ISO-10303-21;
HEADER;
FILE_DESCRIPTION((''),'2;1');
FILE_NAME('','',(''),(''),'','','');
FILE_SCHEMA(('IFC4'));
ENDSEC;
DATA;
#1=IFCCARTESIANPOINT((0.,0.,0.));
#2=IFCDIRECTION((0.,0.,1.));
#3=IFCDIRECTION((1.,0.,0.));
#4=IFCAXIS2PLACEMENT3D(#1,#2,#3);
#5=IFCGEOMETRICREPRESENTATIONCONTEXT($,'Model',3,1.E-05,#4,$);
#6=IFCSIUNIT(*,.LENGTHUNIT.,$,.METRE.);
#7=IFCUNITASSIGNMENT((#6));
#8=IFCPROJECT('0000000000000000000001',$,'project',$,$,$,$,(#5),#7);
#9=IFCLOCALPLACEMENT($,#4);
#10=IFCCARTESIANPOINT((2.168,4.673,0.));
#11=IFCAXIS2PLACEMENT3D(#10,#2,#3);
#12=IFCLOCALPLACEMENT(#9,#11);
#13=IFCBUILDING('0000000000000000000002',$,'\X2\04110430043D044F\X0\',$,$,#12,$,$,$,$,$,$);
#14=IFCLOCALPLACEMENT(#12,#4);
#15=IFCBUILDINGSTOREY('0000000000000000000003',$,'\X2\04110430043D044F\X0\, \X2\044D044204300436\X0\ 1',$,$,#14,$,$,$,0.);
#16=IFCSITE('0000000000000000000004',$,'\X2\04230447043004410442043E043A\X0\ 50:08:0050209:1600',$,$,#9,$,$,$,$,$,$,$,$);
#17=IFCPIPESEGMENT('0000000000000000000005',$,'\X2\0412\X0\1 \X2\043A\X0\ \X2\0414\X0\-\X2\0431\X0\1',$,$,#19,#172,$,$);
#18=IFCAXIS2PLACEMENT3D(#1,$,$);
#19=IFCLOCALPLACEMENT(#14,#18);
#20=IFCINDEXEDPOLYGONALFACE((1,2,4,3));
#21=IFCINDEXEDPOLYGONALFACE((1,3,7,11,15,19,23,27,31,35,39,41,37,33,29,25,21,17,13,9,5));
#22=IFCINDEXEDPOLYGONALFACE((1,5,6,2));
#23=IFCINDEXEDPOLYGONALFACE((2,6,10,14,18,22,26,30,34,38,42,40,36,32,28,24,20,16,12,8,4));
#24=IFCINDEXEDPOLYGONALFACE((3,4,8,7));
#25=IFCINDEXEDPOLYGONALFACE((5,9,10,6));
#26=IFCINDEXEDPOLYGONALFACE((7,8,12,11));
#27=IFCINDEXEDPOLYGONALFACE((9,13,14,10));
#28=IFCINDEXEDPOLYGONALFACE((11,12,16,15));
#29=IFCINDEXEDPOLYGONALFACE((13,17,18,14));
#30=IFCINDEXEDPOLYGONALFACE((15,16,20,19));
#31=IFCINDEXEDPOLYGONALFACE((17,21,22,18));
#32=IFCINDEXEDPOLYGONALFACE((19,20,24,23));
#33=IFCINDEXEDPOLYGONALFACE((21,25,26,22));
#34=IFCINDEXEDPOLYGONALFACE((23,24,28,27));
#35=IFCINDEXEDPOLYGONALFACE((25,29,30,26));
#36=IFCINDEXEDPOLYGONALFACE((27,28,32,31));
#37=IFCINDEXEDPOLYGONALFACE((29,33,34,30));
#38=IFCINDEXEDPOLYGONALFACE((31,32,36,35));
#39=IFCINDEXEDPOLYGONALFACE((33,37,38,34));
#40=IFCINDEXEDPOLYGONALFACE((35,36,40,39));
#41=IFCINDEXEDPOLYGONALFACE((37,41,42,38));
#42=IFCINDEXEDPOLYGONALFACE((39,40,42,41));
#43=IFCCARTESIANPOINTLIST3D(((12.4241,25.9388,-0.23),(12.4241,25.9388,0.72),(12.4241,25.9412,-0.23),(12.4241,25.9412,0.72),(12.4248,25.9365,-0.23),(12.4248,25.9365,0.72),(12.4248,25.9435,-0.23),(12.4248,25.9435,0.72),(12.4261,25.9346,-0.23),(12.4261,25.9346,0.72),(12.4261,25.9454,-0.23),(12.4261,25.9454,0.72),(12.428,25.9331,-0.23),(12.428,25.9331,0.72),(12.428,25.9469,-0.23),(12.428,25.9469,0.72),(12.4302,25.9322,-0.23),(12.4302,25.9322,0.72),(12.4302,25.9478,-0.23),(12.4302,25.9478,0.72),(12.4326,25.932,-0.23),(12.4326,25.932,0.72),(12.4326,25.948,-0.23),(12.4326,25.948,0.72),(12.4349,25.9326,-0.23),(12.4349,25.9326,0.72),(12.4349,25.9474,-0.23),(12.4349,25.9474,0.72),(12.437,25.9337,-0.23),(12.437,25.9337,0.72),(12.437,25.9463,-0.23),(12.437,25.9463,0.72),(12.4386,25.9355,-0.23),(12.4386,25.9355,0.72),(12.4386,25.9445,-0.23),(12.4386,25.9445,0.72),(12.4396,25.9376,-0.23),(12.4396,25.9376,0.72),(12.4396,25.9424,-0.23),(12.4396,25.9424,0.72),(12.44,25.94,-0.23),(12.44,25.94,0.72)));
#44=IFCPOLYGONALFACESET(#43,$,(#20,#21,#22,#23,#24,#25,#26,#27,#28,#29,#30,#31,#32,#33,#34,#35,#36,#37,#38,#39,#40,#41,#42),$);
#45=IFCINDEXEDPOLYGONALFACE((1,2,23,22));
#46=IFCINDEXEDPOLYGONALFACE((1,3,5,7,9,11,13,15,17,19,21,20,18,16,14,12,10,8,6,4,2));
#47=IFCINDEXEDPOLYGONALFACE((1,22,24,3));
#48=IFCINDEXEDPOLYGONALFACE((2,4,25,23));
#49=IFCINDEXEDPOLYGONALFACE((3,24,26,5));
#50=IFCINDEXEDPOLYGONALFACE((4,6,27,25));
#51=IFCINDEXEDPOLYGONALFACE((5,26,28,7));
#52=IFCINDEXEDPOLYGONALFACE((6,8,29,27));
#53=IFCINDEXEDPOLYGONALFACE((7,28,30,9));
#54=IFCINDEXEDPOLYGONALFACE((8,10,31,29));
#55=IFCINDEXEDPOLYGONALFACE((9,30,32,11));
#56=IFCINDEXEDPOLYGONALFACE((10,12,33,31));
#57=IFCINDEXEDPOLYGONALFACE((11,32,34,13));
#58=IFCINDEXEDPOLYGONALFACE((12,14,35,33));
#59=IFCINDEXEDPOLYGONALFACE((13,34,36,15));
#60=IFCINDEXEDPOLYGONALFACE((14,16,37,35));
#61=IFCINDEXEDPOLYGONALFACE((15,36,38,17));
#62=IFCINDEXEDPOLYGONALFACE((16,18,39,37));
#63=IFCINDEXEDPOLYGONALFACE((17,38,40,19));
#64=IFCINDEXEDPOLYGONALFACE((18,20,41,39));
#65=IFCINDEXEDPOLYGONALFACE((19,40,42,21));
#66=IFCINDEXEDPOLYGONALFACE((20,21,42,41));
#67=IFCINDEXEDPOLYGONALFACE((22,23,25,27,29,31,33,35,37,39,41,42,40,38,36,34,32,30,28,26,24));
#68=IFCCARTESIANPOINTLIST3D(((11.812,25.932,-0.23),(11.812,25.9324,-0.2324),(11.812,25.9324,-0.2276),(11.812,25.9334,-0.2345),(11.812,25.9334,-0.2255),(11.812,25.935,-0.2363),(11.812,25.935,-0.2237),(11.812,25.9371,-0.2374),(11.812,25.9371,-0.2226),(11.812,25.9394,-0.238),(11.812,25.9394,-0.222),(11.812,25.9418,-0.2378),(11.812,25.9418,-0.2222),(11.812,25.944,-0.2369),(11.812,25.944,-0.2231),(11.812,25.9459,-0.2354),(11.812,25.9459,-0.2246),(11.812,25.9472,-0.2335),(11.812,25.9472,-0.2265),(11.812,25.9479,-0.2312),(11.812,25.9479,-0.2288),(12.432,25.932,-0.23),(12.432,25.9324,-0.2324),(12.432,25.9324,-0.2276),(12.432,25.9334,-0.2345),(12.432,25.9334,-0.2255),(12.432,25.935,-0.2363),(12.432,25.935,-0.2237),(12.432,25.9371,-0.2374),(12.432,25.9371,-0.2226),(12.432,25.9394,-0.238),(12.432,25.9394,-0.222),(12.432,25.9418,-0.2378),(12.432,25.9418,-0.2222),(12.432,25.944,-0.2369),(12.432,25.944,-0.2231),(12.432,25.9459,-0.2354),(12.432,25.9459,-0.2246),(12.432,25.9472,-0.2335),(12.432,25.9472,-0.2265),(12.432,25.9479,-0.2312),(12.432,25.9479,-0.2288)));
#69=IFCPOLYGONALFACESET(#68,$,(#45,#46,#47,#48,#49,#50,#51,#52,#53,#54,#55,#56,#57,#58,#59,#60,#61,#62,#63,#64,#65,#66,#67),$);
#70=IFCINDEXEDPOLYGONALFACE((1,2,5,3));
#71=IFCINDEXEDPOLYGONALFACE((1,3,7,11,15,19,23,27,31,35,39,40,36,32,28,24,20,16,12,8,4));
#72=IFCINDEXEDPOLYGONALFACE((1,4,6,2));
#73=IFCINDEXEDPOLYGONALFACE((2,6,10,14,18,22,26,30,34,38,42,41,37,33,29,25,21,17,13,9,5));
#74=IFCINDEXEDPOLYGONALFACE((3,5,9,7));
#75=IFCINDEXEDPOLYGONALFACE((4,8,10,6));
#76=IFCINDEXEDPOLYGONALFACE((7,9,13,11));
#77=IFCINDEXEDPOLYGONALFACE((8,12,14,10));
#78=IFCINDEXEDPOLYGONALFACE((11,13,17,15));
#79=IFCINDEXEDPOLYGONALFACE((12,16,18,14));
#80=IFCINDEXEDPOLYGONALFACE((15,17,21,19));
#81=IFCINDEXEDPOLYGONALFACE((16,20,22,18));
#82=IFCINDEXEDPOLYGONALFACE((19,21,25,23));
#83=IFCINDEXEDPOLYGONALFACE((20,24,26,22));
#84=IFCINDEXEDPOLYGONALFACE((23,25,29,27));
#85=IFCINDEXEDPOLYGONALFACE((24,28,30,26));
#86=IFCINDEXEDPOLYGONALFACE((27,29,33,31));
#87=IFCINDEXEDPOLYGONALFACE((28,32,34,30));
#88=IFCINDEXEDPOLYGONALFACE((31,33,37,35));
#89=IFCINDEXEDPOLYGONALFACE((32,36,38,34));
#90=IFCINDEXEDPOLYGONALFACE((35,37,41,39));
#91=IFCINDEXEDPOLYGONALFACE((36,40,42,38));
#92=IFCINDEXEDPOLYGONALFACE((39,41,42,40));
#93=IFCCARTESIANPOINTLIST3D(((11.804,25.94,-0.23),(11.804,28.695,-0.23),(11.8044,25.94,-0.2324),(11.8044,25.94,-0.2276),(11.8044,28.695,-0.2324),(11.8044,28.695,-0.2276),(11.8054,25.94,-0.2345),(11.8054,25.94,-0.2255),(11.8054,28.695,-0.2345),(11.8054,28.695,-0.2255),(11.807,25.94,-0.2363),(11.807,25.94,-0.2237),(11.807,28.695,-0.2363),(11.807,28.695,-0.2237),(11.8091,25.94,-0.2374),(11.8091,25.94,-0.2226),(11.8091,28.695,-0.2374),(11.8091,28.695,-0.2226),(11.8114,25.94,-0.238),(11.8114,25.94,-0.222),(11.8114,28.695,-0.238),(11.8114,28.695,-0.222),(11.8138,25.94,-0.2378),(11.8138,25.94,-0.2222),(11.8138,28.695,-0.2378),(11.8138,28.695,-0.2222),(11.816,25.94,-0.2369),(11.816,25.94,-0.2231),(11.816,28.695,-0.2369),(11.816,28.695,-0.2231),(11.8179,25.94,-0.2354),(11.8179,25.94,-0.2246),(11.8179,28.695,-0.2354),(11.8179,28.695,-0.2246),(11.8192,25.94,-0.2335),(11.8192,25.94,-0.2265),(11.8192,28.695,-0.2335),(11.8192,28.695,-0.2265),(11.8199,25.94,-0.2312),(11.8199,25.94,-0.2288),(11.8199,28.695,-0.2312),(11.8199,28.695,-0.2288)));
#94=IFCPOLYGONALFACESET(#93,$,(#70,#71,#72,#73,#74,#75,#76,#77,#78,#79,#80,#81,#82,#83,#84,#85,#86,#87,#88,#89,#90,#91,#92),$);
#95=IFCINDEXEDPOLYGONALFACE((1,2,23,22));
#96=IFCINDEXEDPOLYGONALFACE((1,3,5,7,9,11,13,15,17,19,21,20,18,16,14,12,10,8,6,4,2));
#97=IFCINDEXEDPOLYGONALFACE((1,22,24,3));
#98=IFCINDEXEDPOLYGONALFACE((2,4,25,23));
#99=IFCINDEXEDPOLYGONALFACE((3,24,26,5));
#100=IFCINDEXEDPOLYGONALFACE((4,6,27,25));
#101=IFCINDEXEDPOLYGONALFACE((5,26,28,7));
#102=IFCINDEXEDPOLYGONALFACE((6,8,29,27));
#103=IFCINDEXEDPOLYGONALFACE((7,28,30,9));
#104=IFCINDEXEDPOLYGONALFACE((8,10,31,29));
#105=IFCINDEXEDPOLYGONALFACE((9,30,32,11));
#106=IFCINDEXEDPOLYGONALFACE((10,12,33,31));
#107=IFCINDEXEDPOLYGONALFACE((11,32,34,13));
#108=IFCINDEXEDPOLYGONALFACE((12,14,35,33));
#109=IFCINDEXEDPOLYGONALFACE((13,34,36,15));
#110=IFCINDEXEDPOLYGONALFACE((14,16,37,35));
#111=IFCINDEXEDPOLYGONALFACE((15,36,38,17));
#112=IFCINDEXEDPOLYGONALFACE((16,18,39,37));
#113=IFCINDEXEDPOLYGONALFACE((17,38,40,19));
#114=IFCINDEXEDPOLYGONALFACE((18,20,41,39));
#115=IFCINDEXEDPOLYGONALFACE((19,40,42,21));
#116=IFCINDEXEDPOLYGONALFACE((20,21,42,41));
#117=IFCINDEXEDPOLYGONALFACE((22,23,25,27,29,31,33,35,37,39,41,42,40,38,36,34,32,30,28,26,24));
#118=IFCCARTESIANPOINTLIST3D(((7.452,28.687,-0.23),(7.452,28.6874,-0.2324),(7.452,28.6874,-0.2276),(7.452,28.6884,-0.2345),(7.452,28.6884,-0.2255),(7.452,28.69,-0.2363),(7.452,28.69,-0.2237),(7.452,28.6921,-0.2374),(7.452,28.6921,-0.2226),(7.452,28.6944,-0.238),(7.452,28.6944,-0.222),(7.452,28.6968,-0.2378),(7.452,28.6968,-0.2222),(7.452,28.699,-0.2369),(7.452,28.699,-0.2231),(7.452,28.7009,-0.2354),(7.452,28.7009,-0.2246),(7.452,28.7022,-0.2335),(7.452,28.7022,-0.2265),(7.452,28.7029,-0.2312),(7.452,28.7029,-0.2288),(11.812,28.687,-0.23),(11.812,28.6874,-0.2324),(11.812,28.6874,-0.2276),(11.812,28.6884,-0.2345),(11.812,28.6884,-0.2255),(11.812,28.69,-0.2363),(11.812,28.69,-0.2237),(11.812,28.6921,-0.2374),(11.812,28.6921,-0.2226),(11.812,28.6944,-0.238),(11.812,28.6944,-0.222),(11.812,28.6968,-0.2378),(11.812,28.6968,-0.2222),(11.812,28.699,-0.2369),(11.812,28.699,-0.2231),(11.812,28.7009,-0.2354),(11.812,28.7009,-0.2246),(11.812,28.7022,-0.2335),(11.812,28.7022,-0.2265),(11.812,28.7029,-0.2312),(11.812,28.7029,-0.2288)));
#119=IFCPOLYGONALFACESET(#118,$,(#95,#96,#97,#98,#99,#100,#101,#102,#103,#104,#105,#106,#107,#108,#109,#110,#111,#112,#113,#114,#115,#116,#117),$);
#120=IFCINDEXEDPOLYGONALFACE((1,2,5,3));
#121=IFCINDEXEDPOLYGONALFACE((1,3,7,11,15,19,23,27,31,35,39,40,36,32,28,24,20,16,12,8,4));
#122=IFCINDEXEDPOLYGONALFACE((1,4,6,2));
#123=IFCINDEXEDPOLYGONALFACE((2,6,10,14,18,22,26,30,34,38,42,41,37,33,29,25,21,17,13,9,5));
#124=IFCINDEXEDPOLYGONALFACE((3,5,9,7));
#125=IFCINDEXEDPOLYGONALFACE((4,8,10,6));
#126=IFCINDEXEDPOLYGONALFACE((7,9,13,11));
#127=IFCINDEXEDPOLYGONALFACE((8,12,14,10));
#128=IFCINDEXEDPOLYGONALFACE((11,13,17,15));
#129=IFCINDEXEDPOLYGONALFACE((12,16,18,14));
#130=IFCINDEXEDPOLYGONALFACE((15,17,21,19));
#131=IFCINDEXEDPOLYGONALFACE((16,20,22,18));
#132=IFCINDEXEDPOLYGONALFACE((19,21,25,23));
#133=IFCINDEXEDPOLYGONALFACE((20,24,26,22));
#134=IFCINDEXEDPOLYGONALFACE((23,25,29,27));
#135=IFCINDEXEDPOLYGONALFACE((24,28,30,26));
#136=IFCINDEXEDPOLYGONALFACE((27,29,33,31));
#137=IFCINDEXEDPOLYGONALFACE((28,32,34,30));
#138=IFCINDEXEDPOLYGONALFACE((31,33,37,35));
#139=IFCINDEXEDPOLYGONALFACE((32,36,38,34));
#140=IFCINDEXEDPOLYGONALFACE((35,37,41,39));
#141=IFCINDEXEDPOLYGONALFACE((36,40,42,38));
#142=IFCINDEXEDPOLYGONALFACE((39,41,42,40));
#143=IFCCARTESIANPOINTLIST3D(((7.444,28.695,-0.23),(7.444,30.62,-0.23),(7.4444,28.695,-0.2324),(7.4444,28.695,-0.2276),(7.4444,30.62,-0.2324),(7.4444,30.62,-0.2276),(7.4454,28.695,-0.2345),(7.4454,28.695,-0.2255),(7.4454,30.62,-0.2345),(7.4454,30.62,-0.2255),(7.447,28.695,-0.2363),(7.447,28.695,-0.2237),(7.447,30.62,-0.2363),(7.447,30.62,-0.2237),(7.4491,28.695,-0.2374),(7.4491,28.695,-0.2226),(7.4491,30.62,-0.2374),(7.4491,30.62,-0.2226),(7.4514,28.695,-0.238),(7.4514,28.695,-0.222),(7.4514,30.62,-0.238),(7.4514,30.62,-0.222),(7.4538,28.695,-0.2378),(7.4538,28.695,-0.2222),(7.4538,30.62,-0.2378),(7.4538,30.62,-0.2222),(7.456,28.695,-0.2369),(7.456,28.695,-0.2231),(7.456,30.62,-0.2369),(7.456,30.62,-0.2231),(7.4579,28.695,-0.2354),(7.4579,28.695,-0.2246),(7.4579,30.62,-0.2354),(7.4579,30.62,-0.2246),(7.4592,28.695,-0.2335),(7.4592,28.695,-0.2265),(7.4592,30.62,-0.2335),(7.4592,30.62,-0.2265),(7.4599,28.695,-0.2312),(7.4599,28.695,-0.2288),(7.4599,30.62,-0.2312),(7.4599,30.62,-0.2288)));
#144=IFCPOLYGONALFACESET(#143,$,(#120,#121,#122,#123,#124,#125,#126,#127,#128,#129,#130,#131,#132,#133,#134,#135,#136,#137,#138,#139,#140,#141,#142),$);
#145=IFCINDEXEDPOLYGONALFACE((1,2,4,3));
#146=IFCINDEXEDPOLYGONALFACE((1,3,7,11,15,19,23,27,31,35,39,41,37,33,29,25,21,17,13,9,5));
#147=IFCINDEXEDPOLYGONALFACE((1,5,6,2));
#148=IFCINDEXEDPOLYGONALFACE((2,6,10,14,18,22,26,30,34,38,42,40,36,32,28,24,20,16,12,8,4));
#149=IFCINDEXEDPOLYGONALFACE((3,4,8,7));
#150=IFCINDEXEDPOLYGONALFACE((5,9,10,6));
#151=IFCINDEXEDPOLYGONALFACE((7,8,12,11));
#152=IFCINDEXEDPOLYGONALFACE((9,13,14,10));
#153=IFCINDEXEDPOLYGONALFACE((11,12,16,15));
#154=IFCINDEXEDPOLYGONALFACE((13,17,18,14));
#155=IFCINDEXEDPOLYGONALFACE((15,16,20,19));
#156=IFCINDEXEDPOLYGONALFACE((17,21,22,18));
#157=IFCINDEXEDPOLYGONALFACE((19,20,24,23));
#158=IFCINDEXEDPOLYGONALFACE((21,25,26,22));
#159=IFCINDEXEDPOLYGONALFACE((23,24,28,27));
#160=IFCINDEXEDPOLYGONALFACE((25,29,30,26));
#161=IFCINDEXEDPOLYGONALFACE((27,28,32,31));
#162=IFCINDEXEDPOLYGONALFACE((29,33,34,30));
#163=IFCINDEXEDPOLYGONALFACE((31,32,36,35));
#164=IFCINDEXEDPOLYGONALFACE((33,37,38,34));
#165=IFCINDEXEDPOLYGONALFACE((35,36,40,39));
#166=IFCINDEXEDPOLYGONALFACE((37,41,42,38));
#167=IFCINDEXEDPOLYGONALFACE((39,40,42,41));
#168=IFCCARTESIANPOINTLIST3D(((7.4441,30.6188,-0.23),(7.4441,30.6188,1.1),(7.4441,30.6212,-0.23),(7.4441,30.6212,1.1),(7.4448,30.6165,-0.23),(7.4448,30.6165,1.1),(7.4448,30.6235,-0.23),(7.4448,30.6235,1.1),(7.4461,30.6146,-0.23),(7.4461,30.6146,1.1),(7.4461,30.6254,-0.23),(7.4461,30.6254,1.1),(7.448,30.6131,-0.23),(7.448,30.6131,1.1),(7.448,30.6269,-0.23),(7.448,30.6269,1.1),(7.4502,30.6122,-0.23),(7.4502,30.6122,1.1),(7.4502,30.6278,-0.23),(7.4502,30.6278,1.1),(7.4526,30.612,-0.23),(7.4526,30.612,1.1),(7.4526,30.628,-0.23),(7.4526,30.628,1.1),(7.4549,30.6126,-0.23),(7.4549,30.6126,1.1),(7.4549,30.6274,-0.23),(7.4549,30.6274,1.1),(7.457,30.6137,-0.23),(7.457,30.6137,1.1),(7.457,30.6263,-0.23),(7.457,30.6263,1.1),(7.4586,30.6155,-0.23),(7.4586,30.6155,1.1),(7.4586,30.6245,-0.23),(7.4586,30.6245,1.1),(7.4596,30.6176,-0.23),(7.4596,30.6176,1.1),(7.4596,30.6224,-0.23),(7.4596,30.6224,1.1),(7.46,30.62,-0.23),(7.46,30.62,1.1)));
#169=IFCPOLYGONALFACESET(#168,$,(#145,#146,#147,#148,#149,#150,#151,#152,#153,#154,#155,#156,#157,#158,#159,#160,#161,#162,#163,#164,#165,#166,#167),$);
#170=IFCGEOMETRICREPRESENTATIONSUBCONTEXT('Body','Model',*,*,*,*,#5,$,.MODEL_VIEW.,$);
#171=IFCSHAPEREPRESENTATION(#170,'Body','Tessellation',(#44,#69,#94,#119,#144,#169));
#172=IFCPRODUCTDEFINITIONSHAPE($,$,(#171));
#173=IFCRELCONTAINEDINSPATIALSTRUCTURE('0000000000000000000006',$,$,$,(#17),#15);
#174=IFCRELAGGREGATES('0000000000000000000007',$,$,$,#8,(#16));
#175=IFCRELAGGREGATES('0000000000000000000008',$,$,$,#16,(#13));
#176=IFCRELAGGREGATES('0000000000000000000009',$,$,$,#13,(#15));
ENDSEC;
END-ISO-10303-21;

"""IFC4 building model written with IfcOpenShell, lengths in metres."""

from ifc_helpers import new_model, si_unit, frame, origin_with_axes, origin_2d, place, context, subcontext, project, spatial, circle, extrude, element, save


model = new_model("IFC4")

# Units and contexts
model_context = context("Model", 3, precision=1e-05, world=origin_with_axes())
body_context = subcontext(model_context, "Body", "Model", "MODEL_VIEW")
ifc_project = project(units=[si_unit("LENGTHUNIT", "METRE")], contexts=[model_context])

# Site, building, storey
site_placement = place(None, origin_with_axes())
site = spatial("IfcSite", under=ifc_project, at=site_placement, Name="Участок 50:08:0050209:1600")
building_placement = place(site_placement, frame((2.168, 4.673, 0.0), z_axis=(0.0, 0.0, 1.0), x_axis=(1.0, 0.0, 0.0)))
building = spatial("IfcBuilding", under=site, at=building_placement, Name="Баня")
storey_placement = place(building_placement, origin_with_axes())
storey = spatial("IfcBuildingStorey", under=building, at=storey_placement, Name="Баня, этаж 1", Elevation=0.0)

# Pipe segment
pipe_segment_1_placement = place(storey_placement, origin_with_axes())
element("IfcPipeSegment", 1, at=pipe_segment_1_placement, inside=storey, Name="В1 к Д-б1", context=body_context, shape_type="SweptSolid", body=[
    extrude(circle(Radius=0.008, at=origin_2d()), frame((12.432, 25.94, 0.72), z_axis=(0.0, 0.0, -1.0), x_axis=(1.0, 0.0, 0.0)), (0.0, 0.0, 1.0), 0.95),
    extrude(circle(Radius=0.008, at=origin_2d()), frame((12.432, 25.94, -0.23), z_axis=(-1.0, 0.0, 0.0), x_axis=(0.0, -1.0, 0.0)), (0.0, 0.0, 1.0), 0.62),
    extrude(circle(Radius=0.008, at=origin_2d()), frame((11.812, 25.94, -0.23), z_axis=(0.0, 1.0, 0.0), x_axis=(-1.0, 0.0, 0.0)), (0.0, 0.0, 1.0), 2.755),
    extrude(circle(Radius=0.008, at=origin_2d()), frame((11.812, 28.695, -0.23), z_axis=(-1.0, 0.0, 0.0), x_axis=(0.0, -1.0, 0.0)), (0.0, 0.0, 1.0), 4.36),
    extrude(circle(Radius=0.008, at=origin_2d()), frame((7.452, 28.695, -0.23), z_axis=(0.0, 1.0, 0.0), x_axis=(-1.0, 0.0, 0.0)), (0.0, 0.0, 1.0), 1.925),
    extrude(circle(Radius=0.008, at=origin_2d()), frame((7.452, 30.62, -0.23), z_axis=(0.0, 0.0, 1.0), x_axis=(1.0, 0.0, 0.0)), (0.0, 0.0, 1.0), 1.33),
])

save(model, "model.ifc")
